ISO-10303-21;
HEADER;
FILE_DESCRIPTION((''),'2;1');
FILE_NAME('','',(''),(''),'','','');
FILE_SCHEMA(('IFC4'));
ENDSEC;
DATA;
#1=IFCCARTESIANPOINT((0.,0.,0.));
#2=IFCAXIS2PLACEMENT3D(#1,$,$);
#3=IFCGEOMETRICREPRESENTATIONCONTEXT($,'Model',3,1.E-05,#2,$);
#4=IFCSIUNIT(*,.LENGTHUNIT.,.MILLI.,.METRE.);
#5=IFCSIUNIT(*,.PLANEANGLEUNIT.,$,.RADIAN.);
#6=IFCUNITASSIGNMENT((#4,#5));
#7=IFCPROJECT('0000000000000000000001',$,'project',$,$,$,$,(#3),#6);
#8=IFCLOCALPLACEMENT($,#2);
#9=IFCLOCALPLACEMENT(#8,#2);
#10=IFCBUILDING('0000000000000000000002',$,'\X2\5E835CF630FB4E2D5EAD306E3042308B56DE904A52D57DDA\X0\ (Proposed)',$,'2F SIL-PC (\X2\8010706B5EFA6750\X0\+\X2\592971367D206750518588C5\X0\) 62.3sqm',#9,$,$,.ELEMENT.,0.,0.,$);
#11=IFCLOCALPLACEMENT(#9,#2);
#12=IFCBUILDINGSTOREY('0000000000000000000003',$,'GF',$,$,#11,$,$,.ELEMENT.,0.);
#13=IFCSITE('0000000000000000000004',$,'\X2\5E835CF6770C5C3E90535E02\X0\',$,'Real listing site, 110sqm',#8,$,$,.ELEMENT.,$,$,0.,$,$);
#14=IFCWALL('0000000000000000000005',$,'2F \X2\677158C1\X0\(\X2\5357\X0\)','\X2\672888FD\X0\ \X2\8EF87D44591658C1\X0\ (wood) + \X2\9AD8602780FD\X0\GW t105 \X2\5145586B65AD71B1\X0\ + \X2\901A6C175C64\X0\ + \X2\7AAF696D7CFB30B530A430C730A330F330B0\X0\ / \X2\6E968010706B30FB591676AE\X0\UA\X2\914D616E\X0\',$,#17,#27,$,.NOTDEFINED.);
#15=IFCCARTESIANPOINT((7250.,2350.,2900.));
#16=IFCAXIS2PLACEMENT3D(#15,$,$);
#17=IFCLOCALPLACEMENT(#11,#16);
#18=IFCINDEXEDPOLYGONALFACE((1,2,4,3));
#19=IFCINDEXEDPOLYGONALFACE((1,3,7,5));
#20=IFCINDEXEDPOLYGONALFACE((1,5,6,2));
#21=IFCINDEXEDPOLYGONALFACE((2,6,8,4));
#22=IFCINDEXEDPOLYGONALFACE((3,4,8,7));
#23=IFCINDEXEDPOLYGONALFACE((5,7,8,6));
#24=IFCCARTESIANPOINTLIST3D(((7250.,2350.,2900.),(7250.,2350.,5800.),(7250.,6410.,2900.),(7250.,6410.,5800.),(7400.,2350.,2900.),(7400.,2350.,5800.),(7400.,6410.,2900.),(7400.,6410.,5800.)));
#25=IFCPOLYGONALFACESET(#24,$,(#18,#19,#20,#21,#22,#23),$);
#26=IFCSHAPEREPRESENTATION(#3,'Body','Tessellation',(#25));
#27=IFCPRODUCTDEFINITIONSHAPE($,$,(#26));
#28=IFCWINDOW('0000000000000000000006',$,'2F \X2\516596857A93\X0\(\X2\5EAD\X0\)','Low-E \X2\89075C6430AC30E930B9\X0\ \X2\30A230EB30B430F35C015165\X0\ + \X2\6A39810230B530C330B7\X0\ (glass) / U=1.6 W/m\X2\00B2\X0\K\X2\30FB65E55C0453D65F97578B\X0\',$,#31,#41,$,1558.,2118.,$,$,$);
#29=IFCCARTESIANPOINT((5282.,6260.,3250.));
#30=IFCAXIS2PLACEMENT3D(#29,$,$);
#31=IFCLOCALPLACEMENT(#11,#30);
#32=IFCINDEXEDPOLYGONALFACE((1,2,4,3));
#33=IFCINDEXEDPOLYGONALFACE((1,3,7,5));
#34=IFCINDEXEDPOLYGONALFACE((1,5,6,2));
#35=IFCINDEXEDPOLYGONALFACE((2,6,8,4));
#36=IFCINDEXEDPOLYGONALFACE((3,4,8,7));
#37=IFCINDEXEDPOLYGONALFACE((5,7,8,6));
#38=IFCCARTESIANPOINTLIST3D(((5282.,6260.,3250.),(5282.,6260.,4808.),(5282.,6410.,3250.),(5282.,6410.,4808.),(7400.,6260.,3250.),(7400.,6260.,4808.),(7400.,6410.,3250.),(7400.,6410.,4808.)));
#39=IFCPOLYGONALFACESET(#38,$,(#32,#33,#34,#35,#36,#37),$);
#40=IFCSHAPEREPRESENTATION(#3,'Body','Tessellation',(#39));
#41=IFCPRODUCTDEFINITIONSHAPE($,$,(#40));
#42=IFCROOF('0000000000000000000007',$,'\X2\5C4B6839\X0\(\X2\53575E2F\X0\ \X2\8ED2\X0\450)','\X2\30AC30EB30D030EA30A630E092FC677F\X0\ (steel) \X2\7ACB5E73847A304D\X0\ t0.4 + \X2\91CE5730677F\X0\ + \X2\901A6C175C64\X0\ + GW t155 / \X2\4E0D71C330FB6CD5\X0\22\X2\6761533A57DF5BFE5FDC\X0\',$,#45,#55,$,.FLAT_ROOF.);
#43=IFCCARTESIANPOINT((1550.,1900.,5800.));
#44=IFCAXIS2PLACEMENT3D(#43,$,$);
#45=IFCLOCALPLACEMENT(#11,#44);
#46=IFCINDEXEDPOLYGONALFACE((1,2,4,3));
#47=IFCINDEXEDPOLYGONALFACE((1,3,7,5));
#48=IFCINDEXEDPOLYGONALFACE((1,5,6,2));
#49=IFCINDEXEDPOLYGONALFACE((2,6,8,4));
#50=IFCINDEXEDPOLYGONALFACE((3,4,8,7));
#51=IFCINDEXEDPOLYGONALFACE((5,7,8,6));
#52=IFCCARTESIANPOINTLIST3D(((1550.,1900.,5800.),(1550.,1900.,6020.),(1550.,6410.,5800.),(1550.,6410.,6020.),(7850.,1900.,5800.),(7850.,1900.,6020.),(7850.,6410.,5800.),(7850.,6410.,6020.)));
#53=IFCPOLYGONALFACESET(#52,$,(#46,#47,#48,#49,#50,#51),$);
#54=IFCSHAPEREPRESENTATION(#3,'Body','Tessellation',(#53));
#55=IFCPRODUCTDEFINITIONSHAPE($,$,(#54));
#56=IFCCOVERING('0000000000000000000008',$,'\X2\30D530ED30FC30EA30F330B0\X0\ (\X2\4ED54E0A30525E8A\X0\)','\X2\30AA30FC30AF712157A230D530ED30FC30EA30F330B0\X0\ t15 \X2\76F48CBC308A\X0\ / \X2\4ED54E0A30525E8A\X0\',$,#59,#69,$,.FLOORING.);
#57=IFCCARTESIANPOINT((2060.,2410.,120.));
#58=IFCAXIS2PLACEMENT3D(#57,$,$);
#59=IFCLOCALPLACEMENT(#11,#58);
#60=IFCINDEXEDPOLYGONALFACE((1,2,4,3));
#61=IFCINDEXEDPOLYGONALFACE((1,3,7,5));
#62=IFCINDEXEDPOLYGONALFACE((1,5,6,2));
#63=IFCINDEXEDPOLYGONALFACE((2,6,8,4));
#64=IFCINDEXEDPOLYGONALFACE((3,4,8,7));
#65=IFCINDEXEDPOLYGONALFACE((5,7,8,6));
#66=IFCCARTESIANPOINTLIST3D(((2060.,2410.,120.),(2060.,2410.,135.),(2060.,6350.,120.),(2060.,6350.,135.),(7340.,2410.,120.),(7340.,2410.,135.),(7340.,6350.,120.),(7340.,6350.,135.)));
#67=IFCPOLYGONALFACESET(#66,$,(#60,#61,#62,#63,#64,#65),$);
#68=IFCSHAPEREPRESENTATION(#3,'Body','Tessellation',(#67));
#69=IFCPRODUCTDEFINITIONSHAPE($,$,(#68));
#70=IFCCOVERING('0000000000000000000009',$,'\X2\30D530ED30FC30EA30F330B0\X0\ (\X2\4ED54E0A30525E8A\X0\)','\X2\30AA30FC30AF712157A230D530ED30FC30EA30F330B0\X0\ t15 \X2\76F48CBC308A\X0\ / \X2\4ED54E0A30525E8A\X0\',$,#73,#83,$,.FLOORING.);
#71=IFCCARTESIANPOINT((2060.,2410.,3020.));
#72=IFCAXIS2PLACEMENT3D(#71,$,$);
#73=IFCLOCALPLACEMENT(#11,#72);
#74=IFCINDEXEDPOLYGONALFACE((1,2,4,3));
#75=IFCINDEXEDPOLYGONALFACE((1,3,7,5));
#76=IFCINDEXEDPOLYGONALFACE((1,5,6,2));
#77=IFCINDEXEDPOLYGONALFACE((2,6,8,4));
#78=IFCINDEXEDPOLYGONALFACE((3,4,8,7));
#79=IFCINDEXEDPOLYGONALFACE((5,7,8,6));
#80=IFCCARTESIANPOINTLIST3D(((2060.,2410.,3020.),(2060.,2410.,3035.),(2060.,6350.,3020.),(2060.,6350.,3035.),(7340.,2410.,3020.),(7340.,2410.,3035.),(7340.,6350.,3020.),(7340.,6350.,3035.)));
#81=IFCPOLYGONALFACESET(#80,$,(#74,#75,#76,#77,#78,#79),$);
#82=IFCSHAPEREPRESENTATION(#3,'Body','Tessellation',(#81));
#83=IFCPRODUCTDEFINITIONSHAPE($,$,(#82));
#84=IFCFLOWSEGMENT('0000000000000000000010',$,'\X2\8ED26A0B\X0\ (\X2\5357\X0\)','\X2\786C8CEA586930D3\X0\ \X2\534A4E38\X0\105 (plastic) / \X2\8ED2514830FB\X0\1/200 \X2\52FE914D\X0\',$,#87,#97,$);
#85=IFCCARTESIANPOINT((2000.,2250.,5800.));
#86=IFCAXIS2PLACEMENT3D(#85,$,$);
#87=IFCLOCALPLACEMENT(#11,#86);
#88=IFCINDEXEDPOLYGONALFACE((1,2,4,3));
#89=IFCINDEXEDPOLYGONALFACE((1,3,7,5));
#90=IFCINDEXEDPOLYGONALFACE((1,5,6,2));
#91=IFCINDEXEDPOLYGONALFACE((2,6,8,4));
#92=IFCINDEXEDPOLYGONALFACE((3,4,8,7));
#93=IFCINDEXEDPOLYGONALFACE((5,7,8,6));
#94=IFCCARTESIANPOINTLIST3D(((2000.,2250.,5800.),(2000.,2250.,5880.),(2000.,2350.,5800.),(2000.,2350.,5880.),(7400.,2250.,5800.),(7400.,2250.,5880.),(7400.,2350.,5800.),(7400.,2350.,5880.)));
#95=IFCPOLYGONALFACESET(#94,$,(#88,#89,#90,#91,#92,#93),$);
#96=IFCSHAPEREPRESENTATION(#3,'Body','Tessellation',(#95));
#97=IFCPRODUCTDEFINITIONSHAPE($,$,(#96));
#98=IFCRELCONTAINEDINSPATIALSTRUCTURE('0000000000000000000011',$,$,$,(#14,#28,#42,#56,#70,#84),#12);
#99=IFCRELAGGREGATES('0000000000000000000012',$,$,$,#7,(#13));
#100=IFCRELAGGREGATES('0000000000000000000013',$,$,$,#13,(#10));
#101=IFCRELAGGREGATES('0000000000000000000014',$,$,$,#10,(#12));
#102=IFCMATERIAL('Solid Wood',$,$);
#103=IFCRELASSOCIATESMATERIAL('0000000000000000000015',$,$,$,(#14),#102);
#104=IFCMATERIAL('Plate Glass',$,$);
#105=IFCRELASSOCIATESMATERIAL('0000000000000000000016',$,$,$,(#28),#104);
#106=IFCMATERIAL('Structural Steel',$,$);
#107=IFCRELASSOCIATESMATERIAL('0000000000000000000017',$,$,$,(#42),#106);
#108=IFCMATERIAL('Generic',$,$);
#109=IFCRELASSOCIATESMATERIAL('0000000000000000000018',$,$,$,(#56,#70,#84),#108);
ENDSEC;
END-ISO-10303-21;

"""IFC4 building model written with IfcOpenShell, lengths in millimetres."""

from ifc_helpers import new_model, si_unit, frame, frame_2d, origin, place, context, project, spatial, rectangle, extrude, material, element, fill, save


model = new_model("IFC4")

# Units and contexts
model_context = context("Model", 3, precision=1e-05, world=origin())
ifc_project = project(units=[si_unit("LENGTHUNIT", "METRE", prefix="MILLI"), si_unit("PLANEANGLEUNIT", "RADIAN")], contexts=[model_context])

# Site, building, storey
site_placement = place(None, origin())
site = spatial("IfcSite", under=ifc_project, at=site_placement, Name="広島県尾道市", ObjectType="Real listing site, 110sqm", CompositionType="ELEMENT", RefElevation=0.0)
building_placement = place(site_placement, origin())
building = spatial("IfcBuilding", under=site, at=building_placement, Name="広島・中庭のある回遊動線 (Proposed)", ObjectType="2F SIL-PC (耐火建材+天然素材内装) 62.3sqm", CompositionType="ELEMENT", ElevationOfRefHeight=0.0, ElevationOfTerrain=0.0)
storey_placement = place(building_placement, origin())
storey = spatial("IfcBuildingStorey", under=building, at=storey_placement, Name="GF", CompositionType="ELEMENT", Elevation=0.0)

# Shared definitions
ifc_material_1 = material(Name="Solid Wood")

# Wall, opening, window
ifc_material_2 = material(Name="Plate Glass")
wall_1_placement = place(storey_placement, frame((7250.0, 2350.0, 2900.0)))
wall_1 = element("IfcWall", 1, at=wall_1_placement, inside=storey, material=ifc_material_1, Name="2F 東壁(南)", Description="木製 軸組外壁 (wood) + 高性能GW t105 充填断熱 + 通気層 + 窯業系サイディング / 準耐火・外皮UA配慮", PredefinedType="NOTDEFINED", context=model_context, shape_type="SweptSolid", body=[
    extrude(rectangle(XDim=150.0, YDim=4060.0, at=frame_2d((75.0, 2030.0))), frame((7250.0, 2350.0, 2900.0)), (0.0, 0.0, 1.0), 2900.0),
])
opening_1_placement = place(storey_placement, frame((5282.0, 6260.0, 3250.0)))
opening_1 = element("IfcOpeningElement", 2, at=opening_1_placement, cuts=wall_1, PredefinedType="NOTDEFINED", context=model_context, shape_type="SweptSolid", body=[
    extrude(rectangle(XDim=2118.0, YDim=150.0, at=frame_2d((1059.0, 75.0))), frame((5282.0, 6260.0, 3250.0)), (0.0, 0.0, 1.0), 1558.0),
])
window_1_placement = place(storey_placement, frame((5282.0, 6260.0, 3250.0)))
window_1 = element("IfcWindow", 3, at=window_1_placement, inside=storey, material=ifc_material_2, Name="2F 入隅窓(庭)", Description="Low-E 複層ガラス アルゴン封入 + 樹脂サッシ (glass) / U=1.6 W/m²K・日射取得型", OverallHeight=1558.0, OverallWidth=2118.0, context=model_context, shape_type="SweptSolid", body=[
    extrude(rectangle(XDim=2118.0, YDim=150.0, at=frame_2d((1059.0, 75.0))), frame((5282.0, 6260.0, 3250.0)), (0.0, 0.0, 1.0), 1558.0),
])
fill(opening_1, window_1)

# Roof
ifc_material_3 = material(Name="Structural Steel")
for number, where, name in (
    (4, (1550.0, 1900.0, 5800.0), "屋根(南帯 軒450)"),
):
    element("IfcRoof", number, at=place(storey_placement, frame(where)), inside=storey, material=ifc_material_3, Name=name, Description="ガルバリウム鋼板 (steel) 立平葺き t0.4 + 野地板 + 通気層 + GW t155 / 不燃・法22条区域対応", PredefinedType="FLAT_ROOF", context=model_context, shape_type="SweptSolid", body=[
        extrude(rectangle(XDim=6300.0, YDim=4510.0, at=frame_2d((3150.0, 2255.0))), frame((1550.0, 1900.0, 5800.0)), (0.0, 0.0, 1.0), 220.0),
    ])

# Coverings
ifc_material_4 = material(Name="Generic")
covering_1_placement = place(storey_placement, frame((2060.0, 2410.0, 120.0)))
element("IfcCovering", 5, at=covering_1_placement, inside=storey, material=ifc_material_4, Name="フローリング (仕上げ床)", Description="オーク無垢フローリング t15 直貼り / 仕上げ床", PredefinedType="FLOORING", context=model_context, shape_type="SweptSolid", body=[
    extrude(rectangle(XDim=5280.0, YDim=3940.0, at=frame_2d((2640.0, 1970.0))), frame((2060.0, 2410.0, 120.0)), (0.0, 0.0, 1.0), 15.0),
])
covering_2_placement = place(storey_placement, frame((2060.0, 2410.0, 3020.0)))
element("IfcCovering", 6, at=covering_2_placement, inside=storey, material=ifc_material_4, Name="フローリング (仕上げ床)", Description="オーク無垢フローリング t15 直貼り / 仕上げ床", PredefinedType="FLOORING", context=model_context, shape_type="SweptSolid", body=[
    extrude(rectangle(XDim=5280.0, YDim=3940.0, at=frame_2d((2640.0, 1970.0))), frame((2060.0, 2410.0, 3020.0)), (0.0, 0.0, 1.0), 15.0),
])

# Flow segment
flow_segment_placement = place(storey_placement, frame((2000.0, 2250.0, 5800.0)))
element("IfcFlowSegment", 7, at=flow_segment_placement, inside=storey, material=ifc_material_4, Name="軒樋 (南)", Description="硬質塩ビ 半丸105 (plastic) / 軒先・1/200 勾配", context=model_context, shape_type="SweptSolid", body=[
    extrude(rectangle(XDim=5400.0, YDim=100.0, at=frame_2d((2700.0, 50.0))), frame((2000.0, 2250.0, 5800.0)), (0.0, 0.0, 1.0), 80.0),
])

save(model, "model.ifc")
